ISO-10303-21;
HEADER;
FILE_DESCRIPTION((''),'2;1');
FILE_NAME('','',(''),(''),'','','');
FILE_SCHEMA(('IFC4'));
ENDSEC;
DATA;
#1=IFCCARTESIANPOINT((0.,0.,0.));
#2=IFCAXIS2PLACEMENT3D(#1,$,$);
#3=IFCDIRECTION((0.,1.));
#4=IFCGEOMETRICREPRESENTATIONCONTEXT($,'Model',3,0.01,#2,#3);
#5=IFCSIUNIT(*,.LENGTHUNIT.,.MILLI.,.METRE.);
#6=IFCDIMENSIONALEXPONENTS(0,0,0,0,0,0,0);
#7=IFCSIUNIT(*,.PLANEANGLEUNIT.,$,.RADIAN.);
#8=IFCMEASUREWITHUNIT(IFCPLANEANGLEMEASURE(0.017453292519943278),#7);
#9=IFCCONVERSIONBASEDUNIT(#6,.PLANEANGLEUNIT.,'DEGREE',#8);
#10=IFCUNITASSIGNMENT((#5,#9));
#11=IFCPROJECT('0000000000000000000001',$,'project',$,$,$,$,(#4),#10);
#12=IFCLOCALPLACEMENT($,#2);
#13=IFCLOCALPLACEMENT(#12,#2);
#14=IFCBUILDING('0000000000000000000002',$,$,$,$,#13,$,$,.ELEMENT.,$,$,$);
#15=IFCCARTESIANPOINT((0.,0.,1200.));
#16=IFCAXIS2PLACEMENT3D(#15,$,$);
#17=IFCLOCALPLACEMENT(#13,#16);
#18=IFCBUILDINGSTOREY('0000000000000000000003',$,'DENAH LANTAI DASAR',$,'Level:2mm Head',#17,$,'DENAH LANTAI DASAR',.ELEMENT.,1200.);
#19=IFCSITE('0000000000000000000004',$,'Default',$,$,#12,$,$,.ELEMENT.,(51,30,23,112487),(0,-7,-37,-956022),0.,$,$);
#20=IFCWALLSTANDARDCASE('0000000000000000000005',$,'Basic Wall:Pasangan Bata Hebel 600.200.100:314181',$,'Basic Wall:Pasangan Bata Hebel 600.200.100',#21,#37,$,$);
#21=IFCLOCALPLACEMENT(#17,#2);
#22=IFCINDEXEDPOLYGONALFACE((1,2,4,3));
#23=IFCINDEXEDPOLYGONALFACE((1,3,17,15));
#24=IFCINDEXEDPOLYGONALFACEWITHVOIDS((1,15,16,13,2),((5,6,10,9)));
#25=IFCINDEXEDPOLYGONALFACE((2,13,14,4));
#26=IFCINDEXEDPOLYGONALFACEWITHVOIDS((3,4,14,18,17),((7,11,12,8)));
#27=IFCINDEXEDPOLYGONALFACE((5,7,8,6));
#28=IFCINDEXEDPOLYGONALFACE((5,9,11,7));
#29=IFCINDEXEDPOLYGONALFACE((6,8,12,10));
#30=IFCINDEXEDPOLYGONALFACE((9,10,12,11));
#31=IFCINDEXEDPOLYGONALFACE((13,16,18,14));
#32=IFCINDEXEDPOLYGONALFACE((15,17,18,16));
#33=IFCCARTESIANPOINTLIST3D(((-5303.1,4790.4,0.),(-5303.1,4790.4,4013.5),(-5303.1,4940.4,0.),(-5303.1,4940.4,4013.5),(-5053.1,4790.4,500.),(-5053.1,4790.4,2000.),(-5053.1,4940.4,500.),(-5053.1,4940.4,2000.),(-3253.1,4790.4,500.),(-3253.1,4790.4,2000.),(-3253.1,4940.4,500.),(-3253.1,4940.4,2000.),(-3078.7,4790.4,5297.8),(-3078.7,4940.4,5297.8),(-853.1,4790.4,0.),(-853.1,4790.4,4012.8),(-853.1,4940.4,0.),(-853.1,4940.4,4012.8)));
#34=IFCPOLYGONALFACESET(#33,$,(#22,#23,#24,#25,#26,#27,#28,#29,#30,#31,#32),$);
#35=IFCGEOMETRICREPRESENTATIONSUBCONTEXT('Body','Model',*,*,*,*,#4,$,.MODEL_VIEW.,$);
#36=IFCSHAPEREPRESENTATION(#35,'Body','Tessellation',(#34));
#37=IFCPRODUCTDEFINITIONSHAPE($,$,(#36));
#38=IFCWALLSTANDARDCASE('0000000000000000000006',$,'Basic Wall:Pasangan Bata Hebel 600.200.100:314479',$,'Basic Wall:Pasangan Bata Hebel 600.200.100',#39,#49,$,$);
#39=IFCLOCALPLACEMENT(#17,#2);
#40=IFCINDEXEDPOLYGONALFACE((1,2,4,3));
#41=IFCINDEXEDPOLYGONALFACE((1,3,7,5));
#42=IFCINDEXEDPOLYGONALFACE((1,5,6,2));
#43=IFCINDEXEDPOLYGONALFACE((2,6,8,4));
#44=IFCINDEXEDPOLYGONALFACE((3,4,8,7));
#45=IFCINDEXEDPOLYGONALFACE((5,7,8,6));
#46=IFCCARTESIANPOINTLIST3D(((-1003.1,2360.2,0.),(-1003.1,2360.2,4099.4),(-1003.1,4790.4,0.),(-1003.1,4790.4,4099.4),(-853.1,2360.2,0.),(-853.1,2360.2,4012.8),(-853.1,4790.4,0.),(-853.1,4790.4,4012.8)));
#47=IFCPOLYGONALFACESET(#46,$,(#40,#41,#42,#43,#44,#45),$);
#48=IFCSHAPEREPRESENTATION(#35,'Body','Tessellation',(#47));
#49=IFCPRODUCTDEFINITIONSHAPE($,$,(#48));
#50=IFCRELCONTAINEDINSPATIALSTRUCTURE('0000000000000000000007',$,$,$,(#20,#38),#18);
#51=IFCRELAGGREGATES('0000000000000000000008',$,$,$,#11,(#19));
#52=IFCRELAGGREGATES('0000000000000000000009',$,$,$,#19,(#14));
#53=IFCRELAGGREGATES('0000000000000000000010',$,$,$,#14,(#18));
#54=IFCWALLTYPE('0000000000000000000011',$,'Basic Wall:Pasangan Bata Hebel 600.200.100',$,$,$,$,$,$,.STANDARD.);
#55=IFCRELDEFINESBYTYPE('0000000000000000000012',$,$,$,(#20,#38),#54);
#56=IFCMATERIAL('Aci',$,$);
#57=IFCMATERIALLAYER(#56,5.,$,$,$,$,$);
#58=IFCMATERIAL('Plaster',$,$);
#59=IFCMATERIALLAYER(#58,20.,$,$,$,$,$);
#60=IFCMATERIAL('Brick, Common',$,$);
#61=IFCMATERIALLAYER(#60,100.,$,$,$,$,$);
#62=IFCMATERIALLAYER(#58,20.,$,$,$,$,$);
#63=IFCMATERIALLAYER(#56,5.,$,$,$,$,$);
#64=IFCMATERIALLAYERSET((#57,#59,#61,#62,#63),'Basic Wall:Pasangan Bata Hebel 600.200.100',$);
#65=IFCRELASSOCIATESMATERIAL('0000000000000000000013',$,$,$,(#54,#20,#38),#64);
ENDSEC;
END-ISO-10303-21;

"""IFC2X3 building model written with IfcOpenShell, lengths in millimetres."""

from ifc_helpers import new_model, entity, si_unit, converted_unit, direction, frame, frame_2d, origin, place, context, subcontext, project, spatial, polyline, rectangle, extrude, clip, bounded_halfspace, material, layer, layer_set, layer_usage, type_object, element, save


model = new_model("IFC2X3")

# Units and contexts
model_context = context("Model", 3, precision=0.01, world=origin(), true_north=direction((0.0, 1.0)))
body_context = subcontext(model_context, "Body", "Model", "MODEL_VIEW")
ifc_project = project(units=[si_unit("LENGTHUNIT", "METRE", prefix="MILLI"), converted_unit("PLANEANGLEUNIT", "DEGREE", entity("IfcPlaneAngleMeasure", 0.017453292519943278), si_unit("PLANEANGLEUNIT", "RADIAN"), dimensions=[0, 0, 0, 0, 0, 0, 0])], contexts=[model_context])

# Site, building, storey
site_placement = place(None, origin())
site = spatial("IfcSite", under=ifc_project, at=site_placement, Name="Default", CompositionType="ELEMENT", RefLatitude=(51, 30, 23, 112487), RefLongitude=(0, -7, -37, -956022), RefElevation=0.0)
building_placement = place(site_placement, origin())
building = spatial("IfcBuilding", under=site, at=building_placement, CompositionType="ELEMENT")
storey_placement = place(building_placement, frame((0.0, 0.0, 1200.0)))
storey = spatial("IfcBuildingStorey", under=building, at=storey_placement, Name="DENAH LANTAI DASAR", ObjectType="Level:2mm Head", LongName="DENAH LANTAI DASAR", CompositionType="ELEMENT", Elevation=1200.0)

# Wall, opening
ifc_material_1 = material(Name="Aci")
ifc_layer_1 = layer(ifc_material_1, 5.0)
ifc_material_2 = material(Name="Plaster")
ifc_layer_2 = layer(ifc_material_2, 20.0)
ifc_material_3 = material(Name="Brick, Common")
ifc_layer_3 = layer(ifc_material_3, 100.0)
ifc_layer_4 = layer(ifc_material_2, 20.0)
ifc_layer_5 = layer(ifc_material_1, 5.0)
ifc_layer_set = layer_set([ifc_layer_1, ifc_layer_2, ifc_layer_3, ifc_layer_4, ifc_layer_5], Name="Basic Wall:Pasangan Bata Hebel 600.200.100")
ifc_layer_usage_1 = layer_usage(ifc_layer_set, "AXIS2", "NEGATIVE", 75.0)
wall_type = type_object("IfcWallType", Name="Basic Wall:Pasangan Bata Hebel 600.200.100", PredefinedType="STANDARD", material=ifc_layer_set)
wall_1_placement = place(storey_placement, frame((-5303.1, 4865.4, 0.0)))
wall_1 = element("IfcWallStandardCase", 1, at=wall_1_placement, inside=storey, type_object=wall_type, material=ifc_layer_usage_1, Name="Basic Wall:Pasangan Bata Hebel 600.200.100:314181", ObjectType="Basic Wall:Pasangan Bata Hebel 600.200.100", context=body_context, shape_type="Clipping", body=[
    clip(clip(extrude(rectangle(XDim=4450.0, YDim=150.0, at=frame_2d((2225.0, 0.0), x_axis=(-1.0, 0.0))), origin(), (0.0, 0.0, 1.0), 5297.8), bounded_halfspace(frame((0.0, -75.0, 4013.5), z_axis=(-0.5, 0.0, 0.866025), x_axis=(0.0, -1.0, 0.0)), False, frame((0.0, -75.0, 4013.5)), polyline([(0.0, 0.0), (150.0, 0.0), (2224.4, 0.0), (2224.4, 150.0), (0.0, 150.0), (0.0, 0.0)]))), bounded_halfspace(frame((2224.4, -75.0, 5297.8), z_axis=(0.5, 0.0, 0.866025), x_axis=(0.0, 1.0, 0.0)), False, frame((2224.4, -75.0, 5297.8)), polyline([(0.0, 0.0), (2075.6, 0.0), (2225.6, 0.0), (2225.6, 150.0), (0.0, 150.0), (0.0, 0.0)]))),
])
opening_placement = place(wall_1_placement, frame((5303.1, -4865.4, 0.0)))
element("IfcOpeningElement", 2, at=opening_placement, cuts=wall_1, ObjectType="Opening", context=body_context, shape_type="SweptSolid", body=[
    extrude(rectangle(XDim=1500.0, YDim=1800.0, at=frame_2d((0.0, 0.0), x_axis=(0.0, 1.0))), frame((-4153.1, 4790.4, 1250.0), z_axis=(0.0, 1.0, 0.0), x_axis=(1.0, 0.0, 0.0)), (0.0, 0.0, 1.0), 150.0),
])

# Wall
ifc_layer_usage_2 = layer_usage(ifc_layer_set, "AXIS2", "NEGATIVE", 75.0)
wall_2_placement = place(storey_placement, frame((-928.1, 4790.4, 0.0), z_axis=(0.0, 0.0, 1.0), x_axis=(0.0, -1.0, 0.0)))
element("IfcWallStandardCase", 3, at=wall_2_placement, inside=storey, type_object=wall_type, material=ifc_layer_usage_2, Name="Basic Wall:Pasangan Bata Hebel 600.200.100:314479", ObjectType="Basic Wall:Pasangan Bata Hebel 600.200.100", context=body_context, shape_type="Clipping", body=[
    clip(extrude(rectangle(XDim=2430.2, YDim=150.0, at=frame_2d((1215.1, 0.0), x_axis=(-1.0, 0.0))), origin(), (0.0, 0.0, 1.0), 4099.4), bounded_halfspace(frame((0.0, -75.0, 4099.4), z_axis=(0.0, 0.5, 0.866025), x_axis=(-1.0, 0.0, 0.0)), False, frame((0.0, -75.0, 4099.4)), polyline([(0.0, 0.0), (2430.2, 0.0), (2430.2, 149.8), (2430.2, 150.0), (0.0, 150.0), (0.0, 0.0)]))),
])

save(model, "model.ifc")
